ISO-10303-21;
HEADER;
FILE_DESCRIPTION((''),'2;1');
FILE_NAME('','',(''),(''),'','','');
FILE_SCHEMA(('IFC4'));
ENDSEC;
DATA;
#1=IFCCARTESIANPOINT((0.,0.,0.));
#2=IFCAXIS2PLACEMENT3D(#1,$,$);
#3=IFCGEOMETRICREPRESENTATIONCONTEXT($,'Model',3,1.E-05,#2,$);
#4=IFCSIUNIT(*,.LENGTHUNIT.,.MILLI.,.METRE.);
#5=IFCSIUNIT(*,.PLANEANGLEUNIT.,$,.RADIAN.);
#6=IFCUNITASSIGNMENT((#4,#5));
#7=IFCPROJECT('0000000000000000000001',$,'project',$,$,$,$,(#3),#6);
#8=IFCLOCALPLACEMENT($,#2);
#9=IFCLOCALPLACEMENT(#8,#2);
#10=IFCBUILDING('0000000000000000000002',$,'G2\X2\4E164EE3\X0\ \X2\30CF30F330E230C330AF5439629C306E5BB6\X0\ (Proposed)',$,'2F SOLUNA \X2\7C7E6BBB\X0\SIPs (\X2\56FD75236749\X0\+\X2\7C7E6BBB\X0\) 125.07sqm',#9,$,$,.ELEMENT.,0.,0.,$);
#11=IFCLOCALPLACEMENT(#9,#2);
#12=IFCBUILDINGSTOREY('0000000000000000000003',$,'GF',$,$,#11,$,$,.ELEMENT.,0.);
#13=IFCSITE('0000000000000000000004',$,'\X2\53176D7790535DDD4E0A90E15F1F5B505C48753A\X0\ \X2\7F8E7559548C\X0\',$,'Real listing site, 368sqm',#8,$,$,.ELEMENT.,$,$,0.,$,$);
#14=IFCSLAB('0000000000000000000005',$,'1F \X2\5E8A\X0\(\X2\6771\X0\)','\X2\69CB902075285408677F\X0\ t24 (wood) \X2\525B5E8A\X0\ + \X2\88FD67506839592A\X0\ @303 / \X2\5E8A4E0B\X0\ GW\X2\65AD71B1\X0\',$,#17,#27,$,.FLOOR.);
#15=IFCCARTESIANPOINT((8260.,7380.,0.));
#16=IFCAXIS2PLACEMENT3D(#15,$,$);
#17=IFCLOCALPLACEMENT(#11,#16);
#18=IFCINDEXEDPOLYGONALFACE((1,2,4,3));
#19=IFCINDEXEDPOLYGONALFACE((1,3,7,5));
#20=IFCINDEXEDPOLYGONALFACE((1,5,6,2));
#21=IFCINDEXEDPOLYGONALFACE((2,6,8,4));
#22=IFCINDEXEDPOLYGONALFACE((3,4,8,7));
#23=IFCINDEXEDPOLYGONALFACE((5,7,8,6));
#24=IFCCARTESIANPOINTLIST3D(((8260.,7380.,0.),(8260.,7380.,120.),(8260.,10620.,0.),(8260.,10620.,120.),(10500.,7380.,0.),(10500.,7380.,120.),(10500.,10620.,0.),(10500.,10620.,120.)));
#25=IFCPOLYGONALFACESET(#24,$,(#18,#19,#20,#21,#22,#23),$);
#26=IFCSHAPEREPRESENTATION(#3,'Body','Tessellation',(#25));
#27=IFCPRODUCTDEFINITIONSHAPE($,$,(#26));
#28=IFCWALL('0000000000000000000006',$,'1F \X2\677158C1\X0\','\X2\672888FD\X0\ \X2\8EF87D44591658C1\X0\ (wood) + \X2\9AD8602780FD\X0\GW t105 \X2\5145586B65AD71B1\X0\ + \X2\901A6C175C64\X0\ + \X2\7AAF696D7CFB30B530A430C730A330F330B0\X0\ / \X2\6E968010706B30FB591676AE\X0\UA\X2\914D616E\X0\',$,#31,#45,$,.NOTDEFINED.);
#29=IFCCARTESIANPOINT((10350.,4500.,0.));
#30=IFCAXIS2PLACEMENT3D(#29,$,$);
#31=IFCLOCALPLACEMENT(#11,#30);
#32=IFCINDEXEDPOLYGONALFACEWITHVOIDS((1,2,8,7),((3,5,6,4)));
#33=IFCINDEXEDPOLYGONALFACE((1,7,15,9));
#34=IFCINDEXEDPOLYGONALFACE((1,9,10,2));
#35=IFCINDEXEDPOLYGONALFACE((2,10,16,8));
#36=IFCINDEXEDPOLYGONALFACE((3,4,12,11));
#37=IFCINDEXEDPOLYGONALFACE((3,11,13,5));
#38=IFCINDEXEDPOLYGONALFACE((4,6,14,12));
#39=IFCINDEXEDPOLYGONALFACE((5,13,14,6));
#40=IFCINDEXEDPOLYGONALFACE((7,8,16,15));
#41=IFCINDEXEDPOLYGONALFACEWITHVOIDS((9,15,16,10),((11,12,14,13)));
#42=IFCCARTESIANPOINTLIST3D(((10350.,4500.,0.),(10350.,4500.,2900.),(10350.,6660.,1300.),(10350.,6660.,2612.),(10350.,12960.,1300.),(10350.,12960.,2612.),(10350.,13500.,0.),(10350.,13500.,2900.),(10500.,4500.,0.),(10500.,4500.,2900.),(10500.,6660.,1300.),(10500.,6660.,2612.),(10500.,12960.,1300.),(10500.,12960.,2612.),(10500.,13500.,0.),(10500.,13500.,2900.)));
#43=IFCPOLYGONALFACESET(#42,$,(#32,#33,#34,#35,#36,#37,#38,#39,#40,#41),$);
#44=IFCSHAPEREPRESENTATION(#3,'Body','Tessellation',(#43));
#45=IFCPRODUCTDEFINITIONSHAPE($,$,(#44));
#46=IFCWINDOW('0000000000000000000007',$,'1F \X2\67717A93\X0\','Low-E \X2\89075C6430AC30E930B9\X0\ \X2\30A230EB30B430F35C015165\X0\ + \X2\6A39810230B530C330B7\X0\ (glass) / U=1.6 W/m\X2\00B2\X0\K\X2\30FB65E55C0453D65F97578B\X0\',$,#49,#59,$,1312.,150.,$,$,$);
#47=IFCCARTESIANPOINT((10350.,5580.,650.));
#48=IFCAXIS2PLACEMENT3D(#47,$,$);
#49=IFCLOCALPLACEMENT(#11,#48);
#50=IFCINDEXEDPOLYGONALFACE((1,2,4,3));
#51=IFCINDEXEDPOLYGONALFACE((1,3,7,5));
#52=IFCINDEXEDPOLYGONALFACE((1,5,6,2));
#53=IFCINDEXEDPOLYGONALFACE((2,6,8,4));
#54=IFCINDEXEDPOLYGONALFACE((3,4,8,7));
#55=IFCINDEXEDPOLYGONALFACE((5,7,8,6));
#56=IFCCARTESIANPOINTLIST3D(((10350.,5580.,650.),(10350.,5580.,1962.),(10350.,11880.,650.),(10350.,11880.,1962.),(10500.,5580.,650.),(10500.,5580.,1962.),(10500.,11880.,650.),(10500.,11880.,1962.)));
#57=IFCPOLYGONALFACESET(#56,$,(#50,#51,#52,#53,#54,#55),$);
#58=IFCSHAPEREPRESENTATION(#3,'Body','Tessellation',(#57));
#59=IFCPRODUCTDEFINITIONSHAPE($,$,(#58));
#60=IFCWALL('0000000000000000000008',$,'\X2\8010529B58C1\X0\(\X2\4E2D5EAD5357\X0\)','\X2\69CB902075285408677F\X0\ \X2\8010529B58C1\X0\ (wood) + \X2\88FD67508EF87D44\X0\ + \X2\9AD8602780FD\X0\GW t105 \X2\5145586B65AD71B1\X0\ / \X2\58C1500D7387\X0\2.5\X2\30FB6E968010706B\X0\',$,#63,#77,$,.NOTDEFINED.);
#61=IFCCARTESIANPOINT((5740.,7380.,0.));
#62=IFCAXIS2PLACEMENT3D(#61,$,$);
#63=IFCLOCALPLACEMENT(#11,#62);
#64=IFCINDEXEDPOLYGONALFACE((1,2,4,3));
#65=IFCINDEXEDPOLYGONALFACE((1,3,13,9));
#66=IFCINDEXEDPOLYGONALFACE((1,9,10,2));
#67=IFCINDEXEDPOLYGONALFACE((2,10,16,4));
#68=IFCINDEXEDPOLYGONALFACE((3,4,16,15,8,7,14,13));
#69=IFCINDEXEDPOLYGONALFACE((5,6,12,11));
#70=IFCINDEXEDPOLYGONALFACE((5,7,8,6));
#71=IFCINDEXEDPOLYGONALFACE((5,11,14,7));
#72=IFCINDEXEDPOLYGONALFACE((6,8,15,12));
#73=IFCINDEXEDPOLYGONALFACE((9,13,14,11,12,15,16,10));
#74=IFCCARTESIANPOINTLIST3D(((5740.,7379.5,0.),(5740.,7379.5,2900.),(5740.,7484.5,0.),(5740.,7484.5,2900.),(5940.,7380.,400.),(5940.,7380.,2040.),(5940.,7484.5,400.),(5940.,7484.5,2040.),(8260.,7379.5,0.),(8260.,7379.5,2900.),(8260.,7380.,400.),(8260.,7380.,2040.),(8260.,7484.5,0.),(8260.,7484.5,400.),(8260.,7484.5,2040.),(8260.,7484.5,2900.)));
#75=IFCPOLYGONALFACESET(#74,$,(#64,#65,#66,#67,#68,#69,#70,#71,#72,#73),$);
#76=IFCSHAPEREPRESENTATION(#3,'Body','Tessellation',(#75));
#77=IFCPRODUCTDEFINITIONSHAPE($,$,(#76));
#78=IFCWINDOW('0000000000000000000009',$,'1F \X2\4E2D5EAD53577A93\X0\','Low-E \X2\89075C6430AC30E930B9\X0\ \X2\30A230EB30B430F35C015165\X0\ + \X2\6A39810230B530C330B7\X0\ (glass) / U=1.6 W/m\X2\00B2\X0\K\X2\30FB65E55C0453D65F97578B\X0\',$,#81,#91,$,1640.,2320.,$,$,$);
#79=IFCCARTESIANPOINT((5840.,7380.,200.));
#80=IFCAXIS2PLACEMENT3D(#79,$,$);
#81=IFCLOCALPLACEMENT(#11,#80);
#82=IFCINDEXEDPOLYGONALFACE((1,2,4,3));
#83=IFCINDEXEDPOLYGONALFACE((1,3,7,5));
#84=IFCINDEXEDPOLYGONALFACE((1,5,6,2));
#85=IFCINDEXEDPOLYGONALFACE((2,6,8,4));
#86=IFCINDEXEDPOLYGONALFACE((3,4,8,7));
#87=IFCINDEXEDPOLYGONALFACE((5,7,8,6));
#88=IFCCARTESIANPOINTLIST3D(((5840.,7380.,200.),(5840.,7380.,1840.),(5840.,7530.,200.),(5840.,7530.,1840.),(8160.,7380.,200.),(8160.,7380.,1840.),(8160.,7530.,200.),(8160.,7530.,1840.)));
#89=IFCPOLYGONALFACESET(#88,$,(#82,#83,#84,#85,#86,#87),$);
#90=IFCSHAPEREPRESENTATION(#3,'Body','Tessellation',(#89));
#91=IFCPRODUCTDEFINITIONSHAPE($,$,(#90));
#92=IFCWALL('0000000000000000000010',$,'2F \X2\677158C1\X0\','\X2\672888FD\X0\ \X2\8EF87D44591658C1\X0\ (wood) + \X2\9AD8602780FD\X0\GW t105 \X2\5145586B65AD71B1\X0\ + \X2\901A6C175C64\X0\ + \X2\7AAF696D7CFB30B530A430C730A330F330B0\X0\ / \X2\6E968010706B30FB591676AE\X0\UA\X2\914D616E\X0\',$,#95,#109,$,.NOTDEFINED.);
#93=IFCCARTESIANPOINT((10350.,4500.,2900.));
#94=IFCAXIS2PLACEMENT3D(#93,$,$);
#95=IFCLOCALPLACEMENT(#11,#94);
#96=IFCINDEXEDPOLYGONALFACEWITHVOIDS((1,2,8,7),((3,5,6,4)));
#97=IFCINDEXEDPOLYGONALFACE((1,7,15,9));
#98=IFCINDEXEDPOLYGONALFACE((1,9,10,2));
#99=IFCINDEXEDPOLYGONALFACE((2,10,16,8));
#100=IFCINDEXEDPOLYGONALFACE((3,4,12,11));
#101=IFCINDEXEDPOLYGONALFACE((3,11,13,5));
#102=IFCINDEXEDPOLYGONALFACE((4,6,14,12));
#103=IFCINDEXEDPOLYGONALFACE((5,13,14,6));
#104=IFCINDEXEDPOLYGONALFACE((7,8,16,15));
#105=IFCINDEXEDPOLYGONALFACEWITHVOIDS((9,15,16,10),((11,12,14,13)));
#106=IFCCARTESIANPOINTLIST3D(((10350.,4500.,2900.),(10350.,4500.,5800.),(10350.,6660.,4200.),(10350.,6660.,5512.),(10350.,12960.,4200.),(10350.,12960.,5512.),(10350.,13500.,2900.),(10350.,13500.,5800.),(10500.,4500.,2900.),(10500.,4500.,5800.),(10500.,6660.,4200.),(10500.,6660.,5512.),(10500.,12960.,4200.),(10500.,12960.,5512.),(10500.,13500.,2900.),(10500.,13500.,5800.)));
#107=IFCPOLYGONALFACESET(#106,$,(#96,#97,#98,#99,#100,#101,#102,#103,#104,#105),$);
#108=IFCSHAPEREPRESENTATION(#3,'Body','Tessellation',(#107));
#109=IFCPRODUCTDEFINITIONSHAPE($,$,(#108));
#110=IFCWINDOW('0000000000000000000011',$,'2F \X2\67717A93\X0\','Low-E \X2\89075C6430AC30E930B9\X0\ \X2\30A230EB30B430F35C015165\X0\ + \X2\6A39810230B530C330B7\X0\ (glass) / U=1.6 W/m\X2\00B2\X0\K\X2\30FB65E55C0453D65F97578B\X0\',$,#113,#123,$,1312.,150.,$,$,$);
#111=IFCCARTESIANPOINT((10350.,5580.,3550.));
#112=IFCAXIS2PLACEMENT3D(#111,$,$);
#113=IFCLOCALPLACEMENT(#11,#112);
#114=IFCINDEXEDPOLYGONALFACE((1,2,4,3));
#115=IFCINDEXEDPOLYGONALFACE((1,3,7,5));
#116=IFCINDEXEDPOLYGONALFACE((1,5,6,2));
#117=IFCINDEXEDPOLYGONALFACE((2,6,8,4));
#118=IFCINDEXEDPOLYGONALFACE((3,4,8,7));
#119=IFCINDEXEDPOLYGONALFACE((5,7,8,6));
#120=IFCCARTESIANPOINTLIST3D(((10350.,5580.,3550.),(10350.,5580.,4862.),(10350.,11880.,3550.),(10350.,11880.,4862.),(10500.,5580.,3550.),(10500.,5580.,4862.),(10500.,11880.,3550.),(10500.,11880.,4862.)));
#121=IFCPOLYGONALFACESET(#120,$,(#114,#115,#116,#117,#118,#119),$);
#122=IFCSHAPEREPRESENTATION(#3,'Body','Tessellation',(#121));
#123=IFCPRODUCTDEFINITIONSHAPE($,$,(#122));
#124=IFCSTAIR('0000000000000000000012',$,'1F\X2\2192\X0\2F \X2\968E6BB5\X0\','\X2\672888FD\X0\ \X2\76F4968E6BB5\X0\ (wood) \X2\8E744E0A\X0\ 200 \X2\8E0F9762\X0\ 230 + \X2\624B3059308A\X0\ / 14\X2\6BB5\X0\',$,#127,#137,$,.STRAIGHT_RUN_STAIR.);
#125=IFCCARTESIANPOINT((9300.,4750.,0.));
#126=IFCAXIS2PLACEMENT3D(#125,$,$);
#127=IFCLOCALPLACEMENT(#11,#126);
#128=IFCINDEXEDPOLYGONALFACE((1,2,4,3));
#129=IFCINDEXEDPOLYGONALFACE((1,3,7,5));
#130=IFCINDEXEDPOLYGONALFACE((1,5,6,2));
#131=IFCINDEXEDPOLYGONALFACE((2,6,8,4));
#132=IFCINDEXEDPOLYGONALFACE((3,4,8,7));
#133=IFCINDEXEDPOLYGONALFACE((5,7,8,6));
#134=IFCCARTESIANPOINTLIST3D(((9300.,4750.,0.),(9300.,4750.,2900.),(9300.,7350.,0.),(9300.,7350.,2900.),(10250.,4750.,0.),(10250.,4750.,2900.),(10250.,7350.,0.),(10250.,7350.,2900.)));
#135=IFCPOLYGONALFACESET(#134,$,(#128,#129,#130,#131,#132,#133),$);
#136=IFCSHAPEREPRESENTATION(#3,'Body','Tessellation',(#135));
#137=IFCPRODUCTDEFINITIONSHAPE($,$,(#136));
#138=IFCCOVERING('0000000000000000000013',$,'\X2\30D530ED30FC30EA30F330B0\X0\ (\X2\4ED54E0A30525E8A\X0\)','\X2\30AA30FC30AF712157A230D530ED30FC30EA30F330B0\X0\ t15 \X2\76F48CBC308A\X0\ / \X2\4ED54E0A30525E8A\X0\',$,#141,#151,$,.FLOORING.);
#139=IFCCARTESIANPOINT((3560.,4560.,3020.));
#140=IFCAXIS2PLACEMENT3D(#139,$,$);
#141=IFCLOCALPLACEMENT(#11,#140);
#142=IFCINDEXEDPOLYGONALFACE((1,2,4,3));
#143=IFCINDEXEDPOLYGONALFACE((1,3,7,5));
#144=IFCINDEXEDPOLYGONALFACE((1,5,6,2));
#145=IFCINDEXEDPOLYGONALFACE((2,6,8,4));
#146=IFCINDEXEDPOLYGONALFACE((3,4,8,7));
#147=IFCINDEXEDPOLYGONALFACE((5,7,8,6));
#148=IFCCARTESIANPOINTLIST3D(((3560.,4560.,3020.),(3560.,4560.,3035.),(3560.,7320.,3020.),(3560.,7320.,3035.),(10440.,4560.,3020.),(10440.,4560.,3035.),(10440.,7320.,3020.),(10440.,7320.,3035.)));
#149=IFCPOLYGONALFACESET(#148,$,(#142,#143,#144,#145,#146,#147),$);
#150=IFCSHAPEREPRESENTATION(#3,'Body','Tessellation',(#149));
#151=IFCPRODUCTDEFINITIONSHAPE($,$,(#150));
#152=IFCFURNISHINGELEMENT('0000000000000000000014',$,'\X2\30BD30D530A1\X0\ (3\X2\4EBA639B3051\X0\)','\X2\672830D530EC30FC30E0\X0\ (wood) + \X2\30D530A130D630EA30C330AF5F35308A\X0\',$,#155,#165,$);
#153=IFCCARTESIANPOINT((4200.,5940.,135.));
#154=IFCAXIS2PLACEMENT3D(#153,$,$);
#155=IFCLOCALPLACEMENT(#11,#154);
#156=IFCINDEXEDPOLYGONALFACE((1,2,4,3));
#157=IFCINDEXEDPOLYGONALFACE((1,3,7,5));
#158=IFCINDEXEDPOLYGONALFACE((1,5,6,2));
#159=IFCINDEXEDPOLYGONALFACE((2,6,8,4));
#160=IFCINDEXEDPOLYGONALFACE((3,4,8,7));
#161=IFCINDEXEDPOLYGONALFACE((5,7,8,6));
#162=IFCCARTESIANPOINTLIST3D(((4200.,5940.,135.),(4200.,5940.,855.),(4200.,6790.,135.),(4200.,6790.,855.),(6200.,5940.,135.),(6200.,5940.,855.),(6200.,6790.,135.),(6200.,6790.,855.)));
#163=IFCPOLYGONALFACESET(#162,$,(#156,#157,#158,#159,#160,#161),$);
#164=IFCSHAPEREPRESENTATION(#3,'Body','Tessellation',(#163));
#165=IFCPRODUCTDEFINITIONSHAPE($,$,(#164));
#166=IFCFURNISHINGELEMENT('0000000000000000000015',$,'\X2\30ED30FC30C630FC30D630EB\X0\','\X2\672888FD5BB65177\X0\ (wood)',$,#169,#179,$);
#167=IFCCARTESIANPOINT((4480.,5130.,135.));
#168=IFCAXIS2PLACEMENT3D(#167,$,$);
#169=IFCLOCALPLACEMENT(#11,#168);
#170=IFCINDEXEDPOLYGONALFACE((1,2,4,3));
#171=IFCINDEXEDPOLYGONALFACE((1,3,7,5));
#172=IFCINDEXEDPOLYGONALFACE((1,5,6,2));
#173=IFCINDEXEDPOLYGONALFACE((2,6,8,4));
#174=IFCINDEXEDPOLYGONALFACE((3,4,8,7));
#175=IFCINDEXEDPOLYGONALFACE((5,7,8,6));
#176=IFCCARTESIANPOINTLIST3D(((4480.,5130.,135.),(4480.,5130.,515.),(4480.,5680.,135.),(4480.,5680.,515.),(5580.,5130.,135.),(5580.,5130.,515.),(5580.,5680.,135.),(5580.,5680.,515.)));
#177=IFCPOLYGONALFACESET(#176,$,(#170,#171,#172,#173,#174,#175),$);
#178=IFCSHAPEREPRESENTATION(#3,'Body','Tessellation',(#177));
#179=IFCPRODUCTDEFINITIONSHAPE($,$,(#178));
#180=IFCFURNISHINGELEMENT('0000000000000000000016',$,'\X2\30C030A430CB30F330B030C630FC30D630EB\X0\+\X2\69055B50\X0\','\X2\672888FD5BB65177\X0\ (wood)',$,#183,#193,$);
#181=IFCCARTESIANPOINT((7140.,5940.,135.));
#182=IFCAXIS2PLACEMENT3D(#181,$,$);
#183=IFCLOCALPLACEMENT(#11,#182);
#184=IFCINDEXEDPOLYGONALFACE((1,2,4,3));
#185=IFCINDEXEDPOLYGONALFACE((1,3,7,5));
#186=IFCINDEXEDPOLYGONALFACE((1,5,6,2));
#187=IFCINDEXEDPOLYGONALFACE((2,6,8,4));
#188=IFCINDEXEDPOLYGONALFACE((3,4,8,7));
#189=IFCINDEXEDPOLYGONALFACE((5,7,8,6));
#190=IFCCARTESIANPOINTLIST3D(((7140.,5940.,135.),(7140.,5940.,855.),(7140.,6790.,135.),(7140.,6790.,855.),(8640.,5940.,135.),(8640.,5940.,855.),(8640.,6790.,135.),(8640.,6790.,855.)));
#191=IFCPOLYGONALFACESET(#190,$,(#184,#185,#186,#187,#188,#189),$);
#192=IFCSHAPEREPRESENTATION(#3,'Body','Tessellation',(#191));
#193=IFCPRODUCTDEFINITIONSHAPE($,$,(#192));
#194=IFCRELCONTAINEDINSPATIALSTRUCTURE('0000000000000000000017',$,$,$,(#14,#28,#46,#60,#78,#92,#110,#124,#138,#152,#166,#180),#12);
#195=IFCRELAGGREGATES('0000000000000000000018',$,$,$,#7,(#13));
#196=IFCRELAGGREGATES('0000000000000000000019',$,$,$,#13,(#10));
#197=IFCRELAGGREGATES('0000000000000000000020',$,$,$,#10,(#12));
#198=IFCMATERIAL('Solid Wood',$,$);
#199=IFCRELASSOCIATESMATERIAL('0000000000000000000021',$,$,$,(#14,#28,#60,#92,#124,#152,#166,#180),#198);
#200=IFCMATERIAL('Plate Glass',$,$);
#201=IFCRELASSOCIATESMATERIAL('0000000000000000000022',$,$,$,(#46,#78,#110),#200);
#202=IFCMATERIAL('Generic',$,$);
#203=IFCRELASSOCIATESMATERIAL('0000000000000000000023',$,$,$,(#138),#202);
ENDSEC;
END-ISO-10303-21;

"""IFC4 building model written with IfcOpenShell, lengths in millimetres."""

from ifc_helpers import new_model, si_unit, frame, frame_2d, origin, place, context, project, spatial, rectangle, extrude, material, element, fill, save


model = new_model("IFC4")

# Units and contexts
model_context = context("Model", 3, precision=1e-05, world=origin())
ifc_project = project(units=[si_unit("LENGTHUNIT", "METRE", prefix="MILLI"), si_unit("PLANEANGLEUNIT", "RADIAN")], contexts=[model_context])

# Site, building, storey
site_placement = place(None, origin())
site = spatial("IfcSite", under=ifc_project, at=site_placement, Name="北海道川上郡弟子屈町 美留和", ObjectType="Real listing site, 368sqm", CompositionType="ELEMENT", RefElevation=0.0)
building_placement = place(site_placement, origin())
building = spatial("IfcBuilding", under=site, at=building_placement, Name="G2世代 ハンモック吹抜の家 (Proposed)", ObjectType="2F SOLUNA 籾殻SIPs (国産杉+籾殻) 125.07sqm", CompositionType="ELEMENT", ElevationOfRefHeight=0.0, ElevationOfTerrain=0.0)
storey_placement = place(building_placement, origin())
storey = spatial("IfcBuildingStorey", under=building, at=storey_placement, Name="GF", CompositionType="ELEMENT", Elevation=0.0)

# Slab
ifc_material_1 = material(Name="Solid Wood")
slab_placement = place(storey_placement, frame((8260.0, 7380.0, 0.0)))
element("IfcSlab", 1, at=slab_placement, inside=storey, material=ifc_material_1, Name="1F 床(東)", Description="構造用合板 t24 (wood) 剛床 + 製材根太 @303 / 床下 GW断熱", PredefinedType="FLOOR", context=model_context, shape_type="SweptSolid", body=[
    extrude(rectangle(XDim=2240.0, YDim=3240.0, at=frame_2d((1120.0, 1620.0))), frame((8260.0, 7380.0, 0.0)), (0.0, 0.0, 1.0), 120.0),
])

# Walls, openings, windows
wall_1_placement = place(storey_placement, frame((10350.0, 4500.0, 0.0)))
wall_1 = element("IfcWall", 2, at=wall_1_placement, inside=storey, material=ifc_material_1, Name="1F 東壁", Description="木製 軸組外壁 (wood) + 高性能GW t105 充填断熱 + 通気層 + 窯業系サイディング / 準耐火・外皮UA配慮", PredefinedType="NOTDEFINED", context=model_context, shape_type="SweptSolid", body=[
    extrude(rectangle(XDim=150.0, YDim=9000.0, at=frame_2d((75.0, 4500.0))), frame((10350.0, 4500.0, 0.0)), (0.0, 0.0, 1.0), 2900.0),
])
opening_1_placement = place(storey_placement, frame((10350.0, 5580.0, 650.0)))
opening_1 = element("IfcOpeningElement", 3, at=opening_1_placement, cuts=wall_1, PredefinedType="NOTDEFINED", context=model_context, shape_type="SweptSolid", body=[
    extrude(rectangle(XDim=150.0, YDim=6300.0, at=frame_2d((75.0, 3150.0))), frame((10350.0, 5580.0, 650.0)), (0.0, 0.0, 1.0), 1312.0),
])
ifc_material_2 = material(Name="Plate Glass")
window_1_placement = place(storey_placement, frame((10350.0, 5580.0, 650.0)))
window_1 = element("IfcWindow", 4, at=window_1_placement, inside=storey, material=ifc_material_2, Name="1F 東窓", Description="Low-E 複層ガラス アルゴン封入 + 樹脂サッシ (glass) / U=1.6 W/m²K・日射取得型", OverallHeight=1312.0, OverallWidth=150.0, context=model_context, shape_type="SweptSolid", body=[
    extrude(rectangle(XDim=150.0, YDim=6300.0, at=frame_2d((75.0, 3150.0))), frame((10350.0, 5580.0, 650.0)), (0.0, 0.0, 1.0), 1312.0),
])
fill(opening_1, window_1)
wall_2_placement = place(storey_placement, frame((5740.0, 7380.0, 0.0)))
wall_2 = element("IfcWall", 5, at=wall_2_placement, inside=storey, material=ifc_material_1, Name="耐力壁(中庭南)", Description="構造用合板 耐力壁 (wood) + 製材軸組 + 高性能GW t105 充填断熱 / 壁倍率2.5・準耐火", PredefinedType="NOTDEFINED", context=model_context, shape_type="SweptSolid", body=[
    extrude(rectangle(XDim=2520.0, YDim=105.0, at=frame_2d((1260.0, 52.0))), frame((5740.0, 7380.0, 0.0)), (0.0, 0.0, 1.0), 2900.0),
])
opening_2_placement = place(storey_placement, frame((5840.0, 7380.0, 200.0)))
opening_2 = element("IfcOpeningElement", 6, at=opening_2_placement, cuts=wall_2, PredefinedType="NOTDEFINED", context=model_context, shape_type="SweptSolid", body=[
    extrude(rectangle(XDim=2320.0, YDim=150.0, at=frame_2d((1160.0, 75.0))), frame((5840.0, 7380.0, 200.0)), (0.0, 0.0, 1.0), 1640.0),
])
window_2_placement = place(storey_placement, frame((5840.0, 7380.0, 200.0)))
window_2 = element("IfcWindow", 7, at=window_2_placement, inside=storey, material=ifc_material_2, Name="1F 中庭南窓", Description="Low-E 複層ガラス アルゴン封入 + 樹脂サッシ (glass) / U=1.6 W/m²K・日射取得型", OverallHeight=1640.0, OverallWidth=2320.0, context=model_context, shape_type="SweptSolid", body=[
    extrude(rectangle(XDim=2320.0, YDim=150.0, at=frame_2d((1160.0, 75.0))), frame((5840.0, 7380.0, 200.0)), (0.0, 0.0, 1.0), 1640.0),
])
fill(opening_2, window_2)

# Wall, opening, window
wall_3_placement = place(storey_placement, frame((10350.0, 4500.0, 2900.0)))
wall_3 = element("IfcWall", 8, at=wall_3_placement, inside=storey, material=ifc_material_1, Name="2F 東壁", Description="木製 軸組外壁 (wood) + 高性能GW t105 充填断熱 + 通気層 + 窯業系サイディング / 準耐火・外皮UA配慮", PredefinedType="NOTDEFINED", context=model_context, shape_type="SweptSolid", body=[
    extrude(rectangle(XDim=150.0, YDim=9000.0, at=frame_2d((75.0, 4500.0))), frame((10350.0, 4500.0, 2900.0)), (0.0, 0.0, 1.0), 2900.0),
])
opening_3_placement = place(storey_placement, frame((10350.0, 5580.0, 3550.0)))
opening_3 = element("IfcOpeningElement", 9, at=opening_3_placement, cuts=wall_3, PredefinedType="NOTDEFINED", context=model_context, shape_type="SweptSolid", body=[
    extrude(rectangle(XDim=150.0, YDim=6300.0, at=frame_2d((75.0, 3150.0))), frame((10350.0, 5580.0, 3550.0)), (0.0, 0.0, 1.0), 1312.0),
])
window_3_placement = place(storey_placement, frame((10350.0, 5580.0, 3550.0)))
window_3 = element("IfcWindow", 10, at=window_3_placement, inside=storey, material=ifc_material_2, Name="2F 東窓", Description="Low-E 複層ガラス アルゴン封入 + 樹脂サッシ (glass) / U=1.6 W/m²K・日射取得型", OverallHeight=1312.0, OverallWidth=150.0, context=model_context, shape_type="SweptSolid", body=[
    extrude(rectangle(XDim=150.0, YDim=6300.0, at=frame_2d((75.0, 3150.0))), frame((10350.0, 5580.0, 3550.0)), (0.0, 0.0, 1.0), 1312.0),
])
fill(opening_3, window_3)

# Stair
stair_placement = place(storey_placement, frame((9300.0, 4750.0, 0.0)))
element("IfcStair", 11, at=stair_placement, inside=storey, material=ifc_material_1, Name="1F→2F 階段", Description="木製 直階段 (wood) 蹴上 200 踏面 230 + 手すり / 14段", PredefinedType="STRAIGHT_RUN_STAIR", context=model_context, shape_type="SweptSolid", body=[
    extrude(rectangle(XDim=950.0, YDim=2600.0, at=frame_2d((475.0, 1300.0))), frame((9300.0, 4750.0, 0.0)), (0.0, 0.0, 1.0), 2900.0),
])

# Covering
ifc_material_3 = material(Name="Generic")
covering_placement = place(storey_placement, frame((3560.0, 4560.0, 3020.0)))
element("IfcCovering", 12, at=covering_placement, inside=storey, material=ifc_material_3, Name="フローリング (仕上げ床)", Description="オーク無垢フローリング t15 直貼り / 仕上げ床", PredefinedType="FLOORING", context=model_context, shape_type="SweptSolid", body=[
    extrude(rectangle(XDim=6880.0, YDim=2760.0, at=frame_2d((3440.0, 1380.0))), frame((3560.0, 4560.0, 3020.0)), (0.0, 0.0, 1.0), 15.0),
])

# Furnishing elements
furnishing_1_placement = place(storey_placement, frame((4200.0, 5940.0, 135.0)))
element("IfcFurnishingElement", 13, at=furnishing_1_placement, inside=storey, material=ifc_material_1, Name="ソファ (3人掛け)", Description="木フレーム (wood) + ファブリック張り", context=model_context, shape_type="SweptSolid", body=[
    extrude(rectangle(XDim=2000.0, YDim=850.0, at=frame_2d((1000.0, 425.0))), frame((4200.0, 5940.0, 135.0)), (0.0, 0.0, 1.0), 720.0),
])
furnishing_2_placement = place(storey_placement, frame((4480.0, 5130.0, 135.0)))
element("IfcFurnishingElement", 14, at=furnishing_2_placement, inside=storey, material=ifc_material_1, Name="ローテーブル", Description="木製家具 (wood)", context=model_context, shape_type="SweptSolid", body=[
    extrude(rectangle(XDim=1100.0, YDim=550.0, at=frame_2d((550.0, 275.0))), frame((4480.0, 5130.0, 135.0)), (0.0, 0.0, 1.0), 380.0),
])
furnishing_3_placement = place(storey_placement, frame((7140.0, 5940.0, 135.0)))
element("IfcFurnishingElement", 15, at=furnishing_3_placement, inside=storey, material=ifc_material_1, Name="ダイニングテーブル+椅子", Description="木製家具 (wood)", context=model_context, shape_type="SweptSolid", body=[
    extrude(rectangle(XDim=1500.0, YDim=850.0, at=frame_2d((750.0, 425.0))), frame((7140.0, 5940.0, 135.0)), (0.0, 0.0, 1.0), 720.0),
])

save(model, "model.ifc")
